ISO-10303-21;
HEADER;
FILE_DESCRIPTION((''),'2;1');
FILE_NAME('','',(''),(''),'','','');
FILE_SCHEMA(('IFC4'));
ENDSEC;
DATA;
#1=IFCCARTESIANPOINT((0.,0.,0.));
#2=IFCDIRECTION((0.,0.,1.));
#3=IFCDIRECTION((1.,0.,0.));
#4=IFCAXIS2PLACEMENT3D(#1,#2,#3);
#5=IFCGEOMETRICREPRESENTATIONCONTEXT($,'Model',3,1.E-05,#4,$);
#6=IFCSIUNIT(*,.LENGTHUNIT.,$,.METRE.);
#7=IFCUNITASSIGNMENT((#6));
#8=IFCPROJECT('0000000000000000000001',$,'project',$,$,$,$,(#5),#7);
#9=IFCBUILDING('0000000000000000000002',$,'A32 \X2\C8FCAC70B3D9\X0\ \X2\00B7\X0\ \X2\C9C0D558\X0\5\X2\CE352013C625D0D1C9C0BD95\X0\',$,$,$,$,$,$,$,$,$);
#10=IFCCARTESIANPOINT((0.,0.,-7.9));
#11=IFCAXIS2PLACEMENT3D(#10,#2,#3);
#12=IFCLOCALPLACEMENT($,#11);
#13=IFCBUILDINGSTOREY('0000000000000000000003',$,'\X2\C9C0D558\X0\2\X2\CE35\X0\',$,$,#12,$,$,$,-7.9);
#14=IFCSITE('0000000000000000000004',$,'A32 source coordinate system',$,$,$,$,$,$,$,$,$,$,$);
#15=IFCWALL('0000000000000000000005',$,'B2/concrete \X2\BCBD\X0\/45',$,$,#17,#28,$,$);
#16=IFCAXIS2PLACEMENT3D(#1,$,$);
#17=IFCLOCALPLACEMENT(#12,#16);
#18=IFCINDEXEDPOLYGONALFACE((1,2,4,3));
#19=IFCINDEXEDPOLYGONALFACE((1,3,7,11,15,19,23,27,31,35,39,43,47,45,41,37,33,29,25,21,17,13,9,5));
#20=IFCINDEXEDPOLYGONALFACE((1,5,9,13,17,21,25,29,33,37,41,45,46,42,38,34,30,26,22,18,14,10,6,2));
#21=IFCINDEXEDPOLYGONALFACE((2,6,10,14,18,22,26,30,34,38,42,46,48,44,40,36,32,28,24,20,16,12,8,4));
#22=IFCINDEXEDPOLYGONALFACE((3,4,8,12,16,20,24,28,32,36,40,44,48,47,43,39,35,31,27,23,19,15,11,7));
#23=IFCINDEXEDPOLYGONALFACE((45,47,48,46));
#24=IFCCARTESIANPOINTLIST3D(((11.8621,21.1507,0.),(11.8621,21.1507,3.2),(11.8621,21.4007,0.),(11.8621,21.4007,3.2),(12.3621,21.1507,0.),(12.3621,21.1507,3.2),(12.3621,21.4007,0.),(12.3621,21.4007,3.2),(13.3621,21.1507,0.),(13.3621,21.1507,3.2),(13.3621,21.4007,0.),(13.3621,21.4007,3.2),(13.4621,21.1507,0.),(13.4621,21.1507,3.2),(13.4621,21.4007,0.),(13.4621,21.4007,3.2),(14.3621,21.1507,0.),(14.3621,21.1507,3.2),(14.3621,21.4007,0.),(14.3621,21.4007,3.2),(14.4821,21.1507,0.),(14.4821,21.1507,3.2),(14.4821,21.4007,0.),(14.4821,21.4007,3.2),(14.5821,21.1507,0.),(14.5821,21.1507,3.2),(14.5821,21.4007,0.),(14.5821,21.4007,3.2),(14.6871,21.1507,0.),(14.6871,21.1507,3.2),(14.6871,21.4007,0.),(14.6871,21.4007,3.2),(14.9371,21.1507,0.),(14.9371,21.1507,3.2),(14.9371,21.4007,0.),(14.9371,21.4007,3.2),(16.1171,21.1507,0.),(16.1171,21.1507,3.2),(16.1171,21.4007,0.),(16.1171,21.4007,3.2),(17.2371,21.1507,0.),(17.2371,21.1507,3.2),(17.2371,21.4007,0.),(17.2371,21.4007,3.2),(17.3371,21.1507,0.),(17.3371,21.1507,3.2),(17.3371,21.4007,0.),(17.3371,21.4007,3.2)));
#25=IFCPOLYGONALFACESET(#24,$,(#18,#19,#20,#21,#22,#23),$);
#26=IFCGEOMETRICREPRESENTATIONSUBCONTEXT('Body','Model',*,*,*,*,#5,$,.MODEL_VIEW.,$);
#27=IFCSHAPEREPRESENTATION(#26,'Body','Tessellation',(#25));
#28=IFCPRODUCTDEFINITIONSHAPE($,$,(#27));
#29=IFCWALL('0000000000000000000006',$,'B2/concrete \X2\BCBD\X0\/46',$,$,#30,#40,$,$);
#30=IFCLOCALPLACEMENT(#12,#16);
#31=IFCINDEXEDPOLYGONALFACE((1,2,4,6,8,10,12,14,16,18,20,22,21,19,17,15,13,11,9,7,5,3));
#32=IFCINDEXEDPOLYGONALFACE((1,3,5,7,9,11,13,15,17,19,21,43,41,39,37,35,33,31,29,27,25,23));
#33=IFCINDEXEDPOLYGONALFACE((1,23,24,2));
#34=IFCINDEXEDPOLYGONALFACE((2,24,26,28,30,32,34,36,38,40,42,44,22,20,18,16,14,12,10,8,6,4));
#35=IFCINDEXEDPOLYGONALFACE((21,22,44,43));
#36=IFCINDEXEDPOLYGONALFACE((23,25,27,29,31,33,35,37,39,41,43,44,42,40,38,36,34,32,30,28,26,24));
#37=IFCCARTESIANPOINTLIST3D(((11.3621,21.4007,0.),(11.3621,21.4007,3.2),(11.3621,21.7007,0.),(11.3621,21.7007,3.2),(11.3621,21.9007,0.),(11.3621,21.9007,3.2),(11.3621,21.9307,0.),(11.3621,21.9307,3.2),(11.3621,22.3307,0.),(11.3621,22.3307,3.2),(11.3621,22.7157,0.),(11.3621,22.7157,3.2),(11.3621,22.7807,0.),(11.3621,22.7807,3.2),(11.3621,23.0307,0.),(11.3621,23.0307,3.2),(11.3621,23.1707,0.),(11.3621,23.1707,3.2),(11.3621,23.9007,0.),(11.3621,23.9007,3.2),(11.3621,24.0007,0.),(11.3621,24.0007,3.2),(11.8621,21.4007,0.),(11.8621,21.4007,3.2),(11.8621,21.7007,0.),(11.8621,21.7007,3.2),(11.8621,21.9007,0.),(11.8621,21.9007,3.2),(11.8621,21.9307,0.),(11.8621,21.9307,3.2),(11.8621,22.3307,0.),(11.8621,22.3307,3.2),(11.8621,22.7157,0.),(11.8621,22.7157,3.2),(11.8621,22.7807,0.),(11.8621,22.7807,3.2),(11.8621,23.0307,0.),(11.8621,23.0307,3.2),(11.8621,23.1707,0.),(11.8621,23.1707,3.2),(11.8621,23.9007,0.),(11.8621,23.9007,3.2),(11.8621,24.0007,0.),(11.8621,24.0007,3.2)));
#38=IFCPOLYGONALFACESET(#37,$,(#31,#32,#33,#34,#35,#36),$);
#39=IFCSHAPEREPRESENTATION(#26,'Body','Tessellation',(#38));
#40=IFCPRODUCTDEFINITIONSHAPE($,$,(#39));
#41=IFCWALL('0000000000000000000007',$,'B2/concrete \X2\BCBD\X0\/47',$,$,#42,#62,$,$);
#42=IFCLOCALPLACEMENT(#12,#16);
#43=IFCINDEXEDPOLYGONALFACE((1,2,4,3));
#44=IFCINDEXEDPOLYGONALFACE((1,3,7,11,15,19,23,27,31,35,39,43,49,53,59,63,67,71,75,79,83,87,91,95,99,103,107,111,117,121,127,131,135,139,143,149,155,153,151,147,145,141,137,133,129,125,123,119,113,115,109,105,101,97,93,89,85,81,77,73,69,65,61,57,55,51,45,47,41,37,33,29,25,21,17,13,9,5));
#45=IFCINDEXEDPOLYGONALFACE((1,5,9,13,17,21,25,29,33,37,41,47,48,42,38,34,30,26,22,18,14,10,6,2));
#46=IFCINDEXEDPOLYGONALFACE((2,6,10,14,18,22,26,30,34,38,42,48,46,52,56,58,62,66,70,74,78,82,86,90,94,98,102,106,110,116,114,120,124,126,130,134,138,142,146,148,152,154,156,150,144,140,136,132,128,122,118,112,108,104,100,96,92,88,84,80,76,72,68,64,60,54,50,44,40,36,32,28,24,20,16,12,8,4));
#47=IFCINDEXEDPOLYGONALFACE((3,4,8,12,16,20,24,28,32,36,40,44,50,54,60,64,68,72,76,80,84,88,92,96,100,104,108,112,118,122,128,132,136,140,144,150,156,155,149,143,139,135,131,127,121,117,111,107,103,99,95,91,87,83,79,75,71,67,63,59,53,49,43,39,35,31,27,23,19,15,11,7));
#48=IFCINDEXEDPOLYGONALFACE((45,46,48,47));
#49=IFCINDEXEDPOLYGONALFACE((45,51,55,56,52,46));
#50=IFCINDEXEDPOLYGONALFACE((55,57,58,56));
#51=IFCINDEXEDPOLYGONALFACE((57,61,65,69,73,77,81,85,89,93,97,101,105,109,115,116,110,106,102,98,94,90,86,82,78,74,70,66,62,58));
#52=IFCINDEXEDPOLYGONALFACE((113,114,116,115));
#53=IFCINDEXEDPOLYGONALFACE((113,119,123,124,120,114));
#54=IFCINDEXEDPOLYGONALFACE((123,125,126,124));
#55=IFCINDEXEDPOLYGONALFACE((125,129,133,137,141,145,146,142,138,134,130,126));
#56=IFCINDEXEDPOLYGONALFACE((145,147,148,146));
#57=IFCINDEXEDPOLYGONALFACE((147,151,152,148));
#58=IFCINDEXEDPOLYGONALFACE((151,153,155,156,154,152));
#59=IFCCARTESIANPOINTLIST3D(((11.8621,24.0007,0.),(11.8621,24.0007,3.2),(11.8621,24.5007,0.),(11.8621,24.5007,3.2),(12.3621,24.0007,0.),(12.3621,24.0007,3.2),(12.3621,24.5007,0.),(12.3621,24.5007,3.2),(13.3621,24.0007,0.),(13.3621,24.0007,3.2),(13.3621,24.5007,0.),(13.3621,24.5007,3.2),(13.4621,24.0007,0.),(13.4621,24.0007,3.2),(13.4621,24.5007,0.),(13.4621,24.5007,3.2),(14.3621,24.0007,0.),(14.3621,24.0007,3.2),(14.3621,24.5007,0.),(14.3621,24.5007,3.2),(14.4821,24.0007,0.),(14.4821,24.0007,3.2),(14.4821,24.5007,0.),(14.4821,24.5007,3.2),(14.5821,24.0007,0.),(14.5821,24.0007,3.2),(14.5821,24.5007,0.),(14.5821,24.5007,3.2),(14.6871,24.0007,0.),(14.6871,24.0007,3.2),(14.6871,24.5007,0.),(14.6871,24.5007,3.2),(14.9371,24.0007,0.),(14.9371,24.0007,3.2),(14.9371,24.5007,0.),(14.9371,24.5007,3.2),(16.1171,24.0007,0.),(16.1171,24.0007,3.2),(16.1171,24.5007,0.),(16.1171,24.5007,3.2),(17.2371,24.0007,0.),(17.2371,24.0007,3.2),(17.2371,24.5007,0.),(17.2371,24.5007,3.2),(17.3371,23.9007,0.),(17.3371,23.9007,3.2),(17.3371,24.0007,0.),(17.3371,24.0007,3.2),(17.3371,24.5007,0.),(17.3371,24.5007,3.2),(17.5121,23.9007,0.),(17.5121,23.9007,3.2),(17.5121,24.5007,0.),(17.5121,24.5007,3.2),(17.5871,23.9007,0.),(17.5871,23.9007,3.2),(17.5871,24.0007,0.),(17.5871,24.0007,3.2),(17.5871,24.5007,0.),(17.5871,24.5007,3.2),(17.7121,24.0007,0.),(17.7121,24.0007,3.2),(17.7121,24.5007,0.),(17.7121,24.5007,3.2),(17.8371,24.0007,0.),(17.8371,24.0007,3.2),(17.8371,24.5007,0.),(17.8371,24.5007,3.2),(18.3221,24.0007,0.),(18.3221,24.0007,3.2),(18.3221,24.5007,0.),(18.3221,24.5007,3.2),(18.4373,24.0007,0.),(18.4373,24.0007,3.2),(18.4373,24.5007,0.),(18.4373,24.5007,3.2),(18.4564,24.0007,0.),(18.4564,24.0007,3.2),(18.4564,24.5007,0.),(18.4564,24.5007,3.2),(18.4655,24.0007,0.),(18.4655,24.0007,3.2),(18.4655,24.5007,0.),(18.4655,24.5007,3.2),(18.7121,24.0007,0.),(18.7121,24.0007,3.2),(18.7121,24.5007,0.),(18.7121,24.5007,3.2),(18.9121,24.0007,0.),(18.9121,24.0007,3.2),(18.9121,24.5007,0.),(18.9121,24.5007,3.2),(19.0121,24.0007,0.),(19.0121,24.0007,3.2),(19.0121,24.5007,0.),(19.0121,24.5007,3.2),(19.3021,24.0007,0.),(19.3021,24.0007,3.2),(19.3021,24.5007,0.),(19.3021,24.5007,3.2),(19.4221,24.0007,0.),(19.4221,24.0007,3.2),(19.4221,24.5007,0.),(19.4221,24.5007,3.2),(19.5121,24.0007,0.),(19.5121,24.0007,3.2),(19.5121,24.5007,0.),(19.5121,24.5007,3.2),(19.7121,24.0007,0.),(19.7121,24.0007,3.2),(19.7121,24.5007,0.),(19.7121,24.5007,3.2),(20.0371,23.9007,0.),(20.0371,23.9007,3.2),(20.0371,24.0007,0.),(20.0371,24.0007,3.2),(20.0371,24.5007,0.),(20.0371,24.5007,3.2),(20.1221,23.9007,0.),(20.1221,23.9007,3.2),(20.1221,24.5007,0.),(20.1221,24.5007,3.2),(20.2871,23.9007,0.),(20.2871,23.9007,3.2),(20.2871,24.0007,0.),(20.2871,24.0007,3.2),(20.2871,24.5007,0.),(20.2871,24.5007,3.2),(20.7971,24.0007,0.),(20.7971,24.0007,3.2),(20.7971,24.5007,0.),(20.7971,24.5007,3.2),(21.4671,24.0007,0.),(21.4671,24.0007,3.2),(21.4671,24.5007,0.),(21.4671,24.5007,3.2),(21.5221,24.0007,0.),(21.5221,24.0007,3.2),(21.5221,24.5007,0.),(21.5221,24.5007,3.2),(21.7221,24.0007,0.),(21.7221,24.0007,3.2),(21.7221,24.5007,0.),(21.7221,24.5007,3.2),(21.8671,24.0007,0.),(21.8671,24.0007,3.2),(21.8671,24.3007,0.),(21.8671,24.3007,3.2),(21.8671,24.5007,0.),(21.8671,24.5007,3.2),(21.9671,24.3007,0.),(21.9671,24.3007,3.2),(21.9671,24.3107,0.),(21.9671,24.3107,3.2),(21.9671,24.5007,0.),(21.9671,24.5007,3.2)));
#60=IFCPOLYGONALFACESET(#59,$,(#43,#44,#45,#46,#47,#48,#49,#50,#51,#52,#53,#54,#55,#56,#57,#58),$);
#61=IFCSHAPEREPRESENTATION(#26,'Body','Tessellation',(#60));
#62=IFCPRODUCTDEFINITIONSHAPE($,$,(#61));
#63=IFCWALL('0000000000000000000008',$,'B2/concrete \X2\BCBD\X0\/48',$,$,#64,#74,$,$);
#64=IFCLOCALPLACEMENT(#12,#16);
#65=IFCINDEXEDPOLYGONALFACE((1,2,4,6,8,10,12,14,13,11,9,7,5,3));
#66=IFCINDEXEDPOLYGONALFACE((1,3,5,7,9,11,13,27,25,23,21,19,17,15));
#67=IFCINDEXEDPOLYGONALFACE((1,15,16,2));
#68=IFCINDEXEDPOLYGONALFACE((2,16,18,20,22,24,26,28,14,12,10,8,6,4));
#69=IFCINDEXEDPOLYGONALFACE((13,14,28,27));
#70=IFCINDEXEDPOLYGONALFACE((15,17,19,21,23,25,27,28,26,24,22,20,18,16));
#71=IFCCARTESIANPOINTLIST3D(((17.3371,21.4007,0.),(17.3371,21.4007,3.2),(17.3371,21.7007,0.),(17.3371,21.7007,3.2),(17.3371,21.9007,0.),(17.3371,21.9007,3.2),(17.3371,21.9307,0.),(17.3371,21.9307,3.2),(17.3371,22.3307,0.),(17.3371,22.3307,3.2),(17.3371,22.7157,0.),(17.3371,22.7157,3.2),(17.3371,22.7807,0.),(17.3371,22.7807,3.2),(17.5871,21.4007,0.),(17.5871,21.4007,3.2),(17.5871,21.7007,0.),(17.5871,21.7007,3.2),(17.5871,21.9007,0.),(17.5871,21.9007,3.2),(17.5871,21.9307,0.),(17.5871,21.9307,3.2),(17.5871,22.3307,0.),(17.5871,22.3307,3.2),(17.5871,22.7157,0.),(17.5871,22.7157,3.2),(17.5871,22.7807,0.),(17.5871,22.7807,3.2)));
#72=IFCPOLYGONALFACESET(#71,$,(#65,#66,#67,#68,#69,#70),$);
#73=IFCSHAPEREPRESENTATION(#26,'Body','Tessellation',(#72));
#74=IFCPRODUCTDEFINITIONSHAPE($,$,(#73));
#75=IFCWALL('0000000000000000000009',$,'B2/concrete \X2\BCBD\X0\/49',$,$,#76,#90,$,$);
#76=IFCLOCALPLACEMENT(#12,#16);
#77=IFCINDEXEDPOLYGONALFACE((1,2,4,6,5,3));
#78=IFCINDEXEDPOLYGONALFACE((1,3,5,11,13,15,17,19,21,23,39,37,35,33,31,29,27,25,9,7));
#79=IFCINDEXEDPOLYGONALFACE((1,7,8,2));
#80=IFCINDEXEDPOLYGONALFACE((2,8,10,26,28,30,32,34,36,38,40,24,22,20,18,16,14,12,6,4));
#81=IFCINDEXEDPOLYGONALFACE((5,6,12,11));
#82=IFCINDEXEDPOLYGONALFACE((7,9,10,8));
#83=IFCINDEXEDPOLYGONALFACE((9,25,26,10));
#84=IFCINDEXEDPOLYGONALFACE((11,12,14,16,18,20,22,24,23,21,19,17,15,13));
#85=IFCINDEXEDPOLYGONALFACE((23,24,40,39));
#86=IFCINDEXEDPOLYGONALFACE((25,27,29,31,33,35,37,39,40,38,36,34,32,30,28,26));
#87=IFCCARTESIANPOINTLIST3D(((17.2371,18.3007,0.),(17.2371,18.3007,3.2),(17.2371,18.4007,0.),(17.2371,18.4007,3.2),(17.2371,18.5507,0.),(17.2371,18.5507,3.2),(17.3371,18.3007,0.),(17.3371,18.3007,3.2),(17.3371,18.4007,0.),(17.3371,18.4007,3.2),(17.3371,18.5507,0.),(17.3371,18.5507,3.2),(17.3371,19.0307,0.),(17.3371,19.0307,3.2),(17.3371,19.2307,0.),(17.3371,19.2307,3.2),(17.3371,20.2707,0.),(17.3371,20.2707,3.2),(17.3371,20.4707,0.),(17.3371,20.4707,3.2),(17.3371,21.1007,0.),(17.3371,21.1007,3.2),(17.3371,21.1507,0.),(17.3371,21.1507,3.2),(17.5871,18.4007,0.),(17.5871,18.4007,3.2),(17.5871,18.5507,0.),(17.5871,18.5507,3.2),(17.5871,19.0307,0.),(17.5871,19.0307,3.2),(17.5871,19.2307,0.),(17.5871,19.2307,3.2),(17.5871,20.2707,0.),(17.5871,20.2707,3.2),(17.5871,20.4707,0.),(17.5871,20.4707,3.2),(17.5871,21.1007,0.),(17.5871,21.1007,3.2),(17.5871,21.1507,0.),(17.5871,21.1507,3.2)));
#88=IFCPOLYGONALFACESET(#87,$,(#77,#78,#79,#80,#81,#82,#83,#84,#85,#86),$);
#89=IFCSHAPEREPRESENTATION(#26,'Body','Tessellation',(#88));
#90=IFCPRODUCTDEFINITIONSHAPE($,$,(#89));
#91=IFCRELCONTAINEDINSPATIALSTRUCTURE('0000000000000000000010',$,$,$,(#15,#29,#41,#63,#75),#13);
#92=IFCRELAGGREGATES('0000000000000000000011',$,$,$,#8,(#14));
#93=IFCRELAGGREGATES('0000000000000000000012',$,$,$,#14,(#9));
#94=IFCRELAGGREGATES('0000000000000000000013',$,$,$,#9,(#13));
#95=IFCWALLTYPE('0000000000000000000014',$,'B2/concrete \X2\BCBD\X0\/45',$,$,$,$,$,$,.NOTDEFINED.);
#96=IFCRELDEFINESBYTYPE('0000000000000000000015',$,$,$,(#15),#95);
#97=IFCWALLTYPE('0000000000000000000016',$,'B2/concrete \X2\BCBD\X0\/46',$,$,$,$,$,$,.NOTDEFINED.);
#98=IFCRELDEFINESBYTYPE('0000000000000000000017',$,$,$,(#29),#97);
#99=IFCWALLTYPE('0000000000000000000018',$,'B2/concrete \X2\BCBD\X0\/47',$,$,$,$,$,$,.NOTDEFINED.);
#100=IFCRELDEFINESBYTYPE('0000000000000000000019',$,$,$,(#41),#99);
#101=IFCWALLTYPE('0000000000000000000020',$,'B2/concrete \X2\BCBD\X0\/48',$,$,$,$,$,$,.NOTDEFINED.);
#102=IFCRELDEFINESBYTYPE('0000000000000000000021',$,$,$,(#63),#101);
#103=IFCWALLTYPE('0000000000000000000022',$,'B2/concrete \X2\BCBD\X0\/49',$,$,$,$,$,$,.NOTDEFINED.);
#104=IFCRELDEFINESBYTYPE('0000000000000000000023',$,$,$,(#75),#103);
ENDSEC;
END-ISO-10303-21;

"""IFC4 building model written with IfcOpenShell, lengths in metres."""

from ifc_helpers import new_model, si_unit, frame, origin, origin_with_axes, place, context, subcontext, project, spatial, polyline, outline, extrude, source, transform, mapped, type_object, type_shapes, element, save


model = new_model("IFC4")

# Units and contexts
model_context = context("Model", 3, precision=1e-05, world=origin_with_axes())
body_context = subcontext(model_context, "Body", "Model", "MODEL_VIEW")
ifc_project = project(units=[si_unit("LENGTHUNIT", "METRE")], contexts=[model_context])

# Site, building, storey
site = spatial("IfcSite", under=ifc_project, Name="A32 source coordinate system")
building = spatial("IfcBuilding", under=site, Name="A32 주거동 · 지하5층–옥탑지붕")
storey_placement = place(None, frame((0.0, 0.0, -7.9), z_axis=(0.0, 0.0, 1.0), x_axis=(1.0, 0.0, 0.0)))
storey = spatial("IfcBuildingStorey", under=building, at=storey_placement, Name="지하2층", Elevation=-7.9)

# Walls
wall_type_1 = type_object("IfcWallType", Name="B2/concrete 벽/45", PredefinedType="NOTDEFINED")
shared_shape_1 = source(origin(), body_context, "Body", "SweptSolid", [
    extrude(outline(polyline([(13.3621, 21.4007), (13.4621, 21.4007), (14.3621, 21.4007), (14.4821, 21.4007), (14.5821, 21.4007), (14.6871, 21.4007), (14.9371, 21.4007), (16.1171, 21.4007), (17.2371, 21.4007), (17.3371, 21.4007), (17.3371, 21.1507), (17.2371, 21.1507), (16.1171, 21.1507), (14.9371, 21.1507), (14.6871, 21.1507), (14.5821, 21.1507), (14.4821, 21.1507), (14.3621, 21.1507), (13.4621, 21.1507), (13.3621, 21.1507), (12.3621, 21.1507), (11.8621, 21.1507), (11.8621, 21.4007), (12.3621, 21.4007), (13.3621, 21.4007)])), origin(), (0.0, 0.0, 1.0), 3.2),
])
type_shapes(wall_type_1, [shared_shape_1])
wall_1_placement = place(storey_placement, origin_with_axes())
element("IfcWall", 1, at=wall_1_placement, inside=storey, type_object=wall_type_1, Name="B2/concrete 벽/45", context=body_context, shape_type="MappedRepresentation", body=[
    mapped(shared_shape_1, transform((0.0, 0.0, 0.0), scale=1.0)),
])
wall_type_2 = type_object("IfcWallType", Name="B2/concrete 벽/46", PredefinedType="NOTDEFINED")
shared_shape_2 = source(origin(), body_context, "Body", "SweptSolid", [
    extrude(outline(polyline([(11.3621, 21.9007), (11.3621, 21.9307), (11.3621, 22.3307), (11.3621, 22.7157), (11.3621, 22.7807), (11.3621, 23.0307), (11.3621, 23.1707), (11.3621, 23.9007), (11.3621, 24.0007), (11.8621, 24.0007), (11.8621, 23.9007), (11.8621, 23.1707), (11.8621, 23.0307), (11.8621, 22.7807), (11.8621, 22.7157), (11.8621, 22.3307), (11.8621, 21.9307), (11.8621, 21.9007), (11.8621, 21.7007), (11.8621, 21.4007), (11.3621, 21.4007), (11.3621, 21.7007), (11.3621, 21.9007)])), origin(), (0.0, 0.0, 1.0), 3.2),
])
type_shapes(wall_type_2, [shared_shape_2])
wall_2_placement = place(storey_placement, origin_with_axes())
element("IfcWall", 2, at=wall_2_placement, inside=storey, type_object=wall_type_2, Name="B2/concrete 벽/46", context=body_context, shape_type="MappedRepresentation", body=[
    mapped(shared_shape_2, transform((0.0, 0.0, 0.0), scale=1.0)),
])
wall_type_3 = type_object("IfcWallType", Name="B2/concrete 벽/47", PredefinedType="NOTDEFINED")
shared_shape_3 = source(origin(), body_context, "Body", "SweptSolid", [
    extrude(outline(polyline([(13.3621, 24.5007), (13.4621, 24.5007), (14.3621, 24.5007), (14.4821, 24.5007), (14.5821, 24.5007), (14.6871, 24.5007), (14.9371, 24.5007), (16.1171, 24.5007), (17.2371, 24.5007), (17.3371, 24.5007), (17.5121, 24.5007), (17.5871, 24.5007), (17.7121, 24.5007), (17.8371, 24.5007), (18.3221, 24.5007), (18.4373, 24.5007), (18.4564, 24.5007), (18.4655, 24.5007), (18.7121, 24.5007), (18.9121, 24.5007), (19.0121, 24.5007), (19.3021, 24.5007), (19.4221, 24.5007), (19.5121, 24.5007), (19.7121, 24.5007), (20.0371, 24.5007), (20.1221, 24.5007), (20.2871, 24.5007), (20.7971, 24.5007), (21.4671, 24.5007), (21.5221, 24.5007), (21.7221, 24.5007), (21.8671, 24.5007), (21.9671, 24.5007), (21.9671, 24.3107), (21.9671, 24.3007), (21.8671, 24.3007), (21.8671, 24.0007), (21.7221, 24.0007), (21.5221, 24.0007), (21.4671, 24.0007), (20.7971, 24.0007), (20.2871, 24.0007), (20.2871, 23.9007), (20.1221, 23.9007), (20.0371, 23.9007), (20.0371, 24.0007), (19.7121, 24.0007), (19.5121, 24.0007), (19.4221, 24.0007), (19.3021, 24.0007), (19.0121, 24.0007), (18.9121, 24.0007), (18.7121, 24.0007), (18.4655, 24.0007), (18.4564, 24.0007), (18.4373, 24.0007), (18.3221, 24.0007), (17.8371, 24.0007), (17.7121, 24.0007), (17.5871, 24.0007), (17.5871, 23.9007), (17.5121, 23.9007), (17.3371, 23.9007), (17.3371, 24.0007), (17.2371, 24.0007), (16.1171, 24.0007), (14.9371, 24.0007), (14.6871, 24.0007), (14.5821, 24.0007), (14.4821, 24.0007), (14.3621, 24.0007), (13.4621, 24.0007), (13.3621, 24.0007), (12.3621, 24.0007), (11.8621, 24.0007), (11.8621, 24.5007), (12.3621, 24.5007), (13.3621, 24.5007)])), origin(), (0.0, 0.0, 1.0), 3.2),
])
type_shapes(wall_type_3, [shared_shape_3])
wall_3_placement = place(storey_placement, origin_with_axes())
element("IfcWall", 3, at=wall_3_placement, inside=storey, type_object=wall_type_3, Name="B2/concrete 벽/47", context=body_context, shape_type="MappedRepresentation", body=[
    mapped(shared_shape_3, transform((0.0, 0.0, 0.0), scale=1.0)),
])
wall_type_4 = type_object("IfcWallType", Name="B2/concrete 벽/48", PredefinedType="NOTDEFINED")
shared_shape_4 = source(origin(), body_context, "Body", "SweptSolid", [
    extrude(outline(polyline([(17.3371, 21.9307), (17.3371, 22.3307), (17.3371, 22.7157), (17.3371, 22.7807), (17.5871, 22.7807), (17.5871, 22.7157), (17.5871, 22.3307), (17.5871, 21.9307), (17.5871, 21.9007), (17.5871, 21.7007), (17.5871, 21.4007), (17.3371, 21.4007), (17.3371, 21.7007), (17.3371, 21.9007), (17.3371, 21.9307)])), origin(), (0.0, 0.0, 1.0), 3.2),
])
type_shapes(wall_type_4, [shared_shape_4])
wall_4_placement = place(storey_placement, origin_with_axes())
element("IfcWall", 4, at=wall_4_placement, inside=storey, type_object=wall_type_4, Name="B2/concrete 벽/48", context=body_context, shape_type="MappedRepresentation", body=[
    mapped(shared_shape_4, transform((0.0, 0.0, 0.0), scale=1.0)),
])
wall_type_5 = type_object("IfcWallType", Name="B2/concrete 벽/49", PredefinedType="NOTDEFINED")
shared_shape_5 = source(origin(), body_context, "Body", "SweptSolid", [
    extrude(outline(polyline([(17.5871, 20.4707), (17.5871, 20.2707), (17.5871, 19.2307), (17.5871, 19.0307), (17.5871, 18.5507), (17.5871, 18.4007), (17.3371, 18.4007), (17.3371, 18.3007), (17.2371, 18.3007), (17.2371, 18.4007), (17.2371, 18.5507), (17.3371, 18.5507), (17.3371, 19.0307), (17.3371, 19.2307), (17.3371, 20.2707), (17.3371, 20.4707), (17.3371, 21.1007), (17.3371, 21.1507), (17.5871, 21.1507), (17.5871, 21.1007), (17.5871, 20.4707)])), origin(), (0.0, 0.0, 1.0), 3.2),
])
type_shapes(wall_type_5, [shared_shape_5])
wall_5_placement = place(storey_placement, origin_with_axes())
element("IfcWall", 5, at=wall_5_placement, inside=storey, type_object=wall_type_5, Name="B2/concrete 벽/49", context=body_context, shape_type="MappedRepresentation", body=[
    mapped(shared_shape_5, transform((0.0, 0.0, 0.0), scale=1.0)),
])

save(model, "model.ifc")
